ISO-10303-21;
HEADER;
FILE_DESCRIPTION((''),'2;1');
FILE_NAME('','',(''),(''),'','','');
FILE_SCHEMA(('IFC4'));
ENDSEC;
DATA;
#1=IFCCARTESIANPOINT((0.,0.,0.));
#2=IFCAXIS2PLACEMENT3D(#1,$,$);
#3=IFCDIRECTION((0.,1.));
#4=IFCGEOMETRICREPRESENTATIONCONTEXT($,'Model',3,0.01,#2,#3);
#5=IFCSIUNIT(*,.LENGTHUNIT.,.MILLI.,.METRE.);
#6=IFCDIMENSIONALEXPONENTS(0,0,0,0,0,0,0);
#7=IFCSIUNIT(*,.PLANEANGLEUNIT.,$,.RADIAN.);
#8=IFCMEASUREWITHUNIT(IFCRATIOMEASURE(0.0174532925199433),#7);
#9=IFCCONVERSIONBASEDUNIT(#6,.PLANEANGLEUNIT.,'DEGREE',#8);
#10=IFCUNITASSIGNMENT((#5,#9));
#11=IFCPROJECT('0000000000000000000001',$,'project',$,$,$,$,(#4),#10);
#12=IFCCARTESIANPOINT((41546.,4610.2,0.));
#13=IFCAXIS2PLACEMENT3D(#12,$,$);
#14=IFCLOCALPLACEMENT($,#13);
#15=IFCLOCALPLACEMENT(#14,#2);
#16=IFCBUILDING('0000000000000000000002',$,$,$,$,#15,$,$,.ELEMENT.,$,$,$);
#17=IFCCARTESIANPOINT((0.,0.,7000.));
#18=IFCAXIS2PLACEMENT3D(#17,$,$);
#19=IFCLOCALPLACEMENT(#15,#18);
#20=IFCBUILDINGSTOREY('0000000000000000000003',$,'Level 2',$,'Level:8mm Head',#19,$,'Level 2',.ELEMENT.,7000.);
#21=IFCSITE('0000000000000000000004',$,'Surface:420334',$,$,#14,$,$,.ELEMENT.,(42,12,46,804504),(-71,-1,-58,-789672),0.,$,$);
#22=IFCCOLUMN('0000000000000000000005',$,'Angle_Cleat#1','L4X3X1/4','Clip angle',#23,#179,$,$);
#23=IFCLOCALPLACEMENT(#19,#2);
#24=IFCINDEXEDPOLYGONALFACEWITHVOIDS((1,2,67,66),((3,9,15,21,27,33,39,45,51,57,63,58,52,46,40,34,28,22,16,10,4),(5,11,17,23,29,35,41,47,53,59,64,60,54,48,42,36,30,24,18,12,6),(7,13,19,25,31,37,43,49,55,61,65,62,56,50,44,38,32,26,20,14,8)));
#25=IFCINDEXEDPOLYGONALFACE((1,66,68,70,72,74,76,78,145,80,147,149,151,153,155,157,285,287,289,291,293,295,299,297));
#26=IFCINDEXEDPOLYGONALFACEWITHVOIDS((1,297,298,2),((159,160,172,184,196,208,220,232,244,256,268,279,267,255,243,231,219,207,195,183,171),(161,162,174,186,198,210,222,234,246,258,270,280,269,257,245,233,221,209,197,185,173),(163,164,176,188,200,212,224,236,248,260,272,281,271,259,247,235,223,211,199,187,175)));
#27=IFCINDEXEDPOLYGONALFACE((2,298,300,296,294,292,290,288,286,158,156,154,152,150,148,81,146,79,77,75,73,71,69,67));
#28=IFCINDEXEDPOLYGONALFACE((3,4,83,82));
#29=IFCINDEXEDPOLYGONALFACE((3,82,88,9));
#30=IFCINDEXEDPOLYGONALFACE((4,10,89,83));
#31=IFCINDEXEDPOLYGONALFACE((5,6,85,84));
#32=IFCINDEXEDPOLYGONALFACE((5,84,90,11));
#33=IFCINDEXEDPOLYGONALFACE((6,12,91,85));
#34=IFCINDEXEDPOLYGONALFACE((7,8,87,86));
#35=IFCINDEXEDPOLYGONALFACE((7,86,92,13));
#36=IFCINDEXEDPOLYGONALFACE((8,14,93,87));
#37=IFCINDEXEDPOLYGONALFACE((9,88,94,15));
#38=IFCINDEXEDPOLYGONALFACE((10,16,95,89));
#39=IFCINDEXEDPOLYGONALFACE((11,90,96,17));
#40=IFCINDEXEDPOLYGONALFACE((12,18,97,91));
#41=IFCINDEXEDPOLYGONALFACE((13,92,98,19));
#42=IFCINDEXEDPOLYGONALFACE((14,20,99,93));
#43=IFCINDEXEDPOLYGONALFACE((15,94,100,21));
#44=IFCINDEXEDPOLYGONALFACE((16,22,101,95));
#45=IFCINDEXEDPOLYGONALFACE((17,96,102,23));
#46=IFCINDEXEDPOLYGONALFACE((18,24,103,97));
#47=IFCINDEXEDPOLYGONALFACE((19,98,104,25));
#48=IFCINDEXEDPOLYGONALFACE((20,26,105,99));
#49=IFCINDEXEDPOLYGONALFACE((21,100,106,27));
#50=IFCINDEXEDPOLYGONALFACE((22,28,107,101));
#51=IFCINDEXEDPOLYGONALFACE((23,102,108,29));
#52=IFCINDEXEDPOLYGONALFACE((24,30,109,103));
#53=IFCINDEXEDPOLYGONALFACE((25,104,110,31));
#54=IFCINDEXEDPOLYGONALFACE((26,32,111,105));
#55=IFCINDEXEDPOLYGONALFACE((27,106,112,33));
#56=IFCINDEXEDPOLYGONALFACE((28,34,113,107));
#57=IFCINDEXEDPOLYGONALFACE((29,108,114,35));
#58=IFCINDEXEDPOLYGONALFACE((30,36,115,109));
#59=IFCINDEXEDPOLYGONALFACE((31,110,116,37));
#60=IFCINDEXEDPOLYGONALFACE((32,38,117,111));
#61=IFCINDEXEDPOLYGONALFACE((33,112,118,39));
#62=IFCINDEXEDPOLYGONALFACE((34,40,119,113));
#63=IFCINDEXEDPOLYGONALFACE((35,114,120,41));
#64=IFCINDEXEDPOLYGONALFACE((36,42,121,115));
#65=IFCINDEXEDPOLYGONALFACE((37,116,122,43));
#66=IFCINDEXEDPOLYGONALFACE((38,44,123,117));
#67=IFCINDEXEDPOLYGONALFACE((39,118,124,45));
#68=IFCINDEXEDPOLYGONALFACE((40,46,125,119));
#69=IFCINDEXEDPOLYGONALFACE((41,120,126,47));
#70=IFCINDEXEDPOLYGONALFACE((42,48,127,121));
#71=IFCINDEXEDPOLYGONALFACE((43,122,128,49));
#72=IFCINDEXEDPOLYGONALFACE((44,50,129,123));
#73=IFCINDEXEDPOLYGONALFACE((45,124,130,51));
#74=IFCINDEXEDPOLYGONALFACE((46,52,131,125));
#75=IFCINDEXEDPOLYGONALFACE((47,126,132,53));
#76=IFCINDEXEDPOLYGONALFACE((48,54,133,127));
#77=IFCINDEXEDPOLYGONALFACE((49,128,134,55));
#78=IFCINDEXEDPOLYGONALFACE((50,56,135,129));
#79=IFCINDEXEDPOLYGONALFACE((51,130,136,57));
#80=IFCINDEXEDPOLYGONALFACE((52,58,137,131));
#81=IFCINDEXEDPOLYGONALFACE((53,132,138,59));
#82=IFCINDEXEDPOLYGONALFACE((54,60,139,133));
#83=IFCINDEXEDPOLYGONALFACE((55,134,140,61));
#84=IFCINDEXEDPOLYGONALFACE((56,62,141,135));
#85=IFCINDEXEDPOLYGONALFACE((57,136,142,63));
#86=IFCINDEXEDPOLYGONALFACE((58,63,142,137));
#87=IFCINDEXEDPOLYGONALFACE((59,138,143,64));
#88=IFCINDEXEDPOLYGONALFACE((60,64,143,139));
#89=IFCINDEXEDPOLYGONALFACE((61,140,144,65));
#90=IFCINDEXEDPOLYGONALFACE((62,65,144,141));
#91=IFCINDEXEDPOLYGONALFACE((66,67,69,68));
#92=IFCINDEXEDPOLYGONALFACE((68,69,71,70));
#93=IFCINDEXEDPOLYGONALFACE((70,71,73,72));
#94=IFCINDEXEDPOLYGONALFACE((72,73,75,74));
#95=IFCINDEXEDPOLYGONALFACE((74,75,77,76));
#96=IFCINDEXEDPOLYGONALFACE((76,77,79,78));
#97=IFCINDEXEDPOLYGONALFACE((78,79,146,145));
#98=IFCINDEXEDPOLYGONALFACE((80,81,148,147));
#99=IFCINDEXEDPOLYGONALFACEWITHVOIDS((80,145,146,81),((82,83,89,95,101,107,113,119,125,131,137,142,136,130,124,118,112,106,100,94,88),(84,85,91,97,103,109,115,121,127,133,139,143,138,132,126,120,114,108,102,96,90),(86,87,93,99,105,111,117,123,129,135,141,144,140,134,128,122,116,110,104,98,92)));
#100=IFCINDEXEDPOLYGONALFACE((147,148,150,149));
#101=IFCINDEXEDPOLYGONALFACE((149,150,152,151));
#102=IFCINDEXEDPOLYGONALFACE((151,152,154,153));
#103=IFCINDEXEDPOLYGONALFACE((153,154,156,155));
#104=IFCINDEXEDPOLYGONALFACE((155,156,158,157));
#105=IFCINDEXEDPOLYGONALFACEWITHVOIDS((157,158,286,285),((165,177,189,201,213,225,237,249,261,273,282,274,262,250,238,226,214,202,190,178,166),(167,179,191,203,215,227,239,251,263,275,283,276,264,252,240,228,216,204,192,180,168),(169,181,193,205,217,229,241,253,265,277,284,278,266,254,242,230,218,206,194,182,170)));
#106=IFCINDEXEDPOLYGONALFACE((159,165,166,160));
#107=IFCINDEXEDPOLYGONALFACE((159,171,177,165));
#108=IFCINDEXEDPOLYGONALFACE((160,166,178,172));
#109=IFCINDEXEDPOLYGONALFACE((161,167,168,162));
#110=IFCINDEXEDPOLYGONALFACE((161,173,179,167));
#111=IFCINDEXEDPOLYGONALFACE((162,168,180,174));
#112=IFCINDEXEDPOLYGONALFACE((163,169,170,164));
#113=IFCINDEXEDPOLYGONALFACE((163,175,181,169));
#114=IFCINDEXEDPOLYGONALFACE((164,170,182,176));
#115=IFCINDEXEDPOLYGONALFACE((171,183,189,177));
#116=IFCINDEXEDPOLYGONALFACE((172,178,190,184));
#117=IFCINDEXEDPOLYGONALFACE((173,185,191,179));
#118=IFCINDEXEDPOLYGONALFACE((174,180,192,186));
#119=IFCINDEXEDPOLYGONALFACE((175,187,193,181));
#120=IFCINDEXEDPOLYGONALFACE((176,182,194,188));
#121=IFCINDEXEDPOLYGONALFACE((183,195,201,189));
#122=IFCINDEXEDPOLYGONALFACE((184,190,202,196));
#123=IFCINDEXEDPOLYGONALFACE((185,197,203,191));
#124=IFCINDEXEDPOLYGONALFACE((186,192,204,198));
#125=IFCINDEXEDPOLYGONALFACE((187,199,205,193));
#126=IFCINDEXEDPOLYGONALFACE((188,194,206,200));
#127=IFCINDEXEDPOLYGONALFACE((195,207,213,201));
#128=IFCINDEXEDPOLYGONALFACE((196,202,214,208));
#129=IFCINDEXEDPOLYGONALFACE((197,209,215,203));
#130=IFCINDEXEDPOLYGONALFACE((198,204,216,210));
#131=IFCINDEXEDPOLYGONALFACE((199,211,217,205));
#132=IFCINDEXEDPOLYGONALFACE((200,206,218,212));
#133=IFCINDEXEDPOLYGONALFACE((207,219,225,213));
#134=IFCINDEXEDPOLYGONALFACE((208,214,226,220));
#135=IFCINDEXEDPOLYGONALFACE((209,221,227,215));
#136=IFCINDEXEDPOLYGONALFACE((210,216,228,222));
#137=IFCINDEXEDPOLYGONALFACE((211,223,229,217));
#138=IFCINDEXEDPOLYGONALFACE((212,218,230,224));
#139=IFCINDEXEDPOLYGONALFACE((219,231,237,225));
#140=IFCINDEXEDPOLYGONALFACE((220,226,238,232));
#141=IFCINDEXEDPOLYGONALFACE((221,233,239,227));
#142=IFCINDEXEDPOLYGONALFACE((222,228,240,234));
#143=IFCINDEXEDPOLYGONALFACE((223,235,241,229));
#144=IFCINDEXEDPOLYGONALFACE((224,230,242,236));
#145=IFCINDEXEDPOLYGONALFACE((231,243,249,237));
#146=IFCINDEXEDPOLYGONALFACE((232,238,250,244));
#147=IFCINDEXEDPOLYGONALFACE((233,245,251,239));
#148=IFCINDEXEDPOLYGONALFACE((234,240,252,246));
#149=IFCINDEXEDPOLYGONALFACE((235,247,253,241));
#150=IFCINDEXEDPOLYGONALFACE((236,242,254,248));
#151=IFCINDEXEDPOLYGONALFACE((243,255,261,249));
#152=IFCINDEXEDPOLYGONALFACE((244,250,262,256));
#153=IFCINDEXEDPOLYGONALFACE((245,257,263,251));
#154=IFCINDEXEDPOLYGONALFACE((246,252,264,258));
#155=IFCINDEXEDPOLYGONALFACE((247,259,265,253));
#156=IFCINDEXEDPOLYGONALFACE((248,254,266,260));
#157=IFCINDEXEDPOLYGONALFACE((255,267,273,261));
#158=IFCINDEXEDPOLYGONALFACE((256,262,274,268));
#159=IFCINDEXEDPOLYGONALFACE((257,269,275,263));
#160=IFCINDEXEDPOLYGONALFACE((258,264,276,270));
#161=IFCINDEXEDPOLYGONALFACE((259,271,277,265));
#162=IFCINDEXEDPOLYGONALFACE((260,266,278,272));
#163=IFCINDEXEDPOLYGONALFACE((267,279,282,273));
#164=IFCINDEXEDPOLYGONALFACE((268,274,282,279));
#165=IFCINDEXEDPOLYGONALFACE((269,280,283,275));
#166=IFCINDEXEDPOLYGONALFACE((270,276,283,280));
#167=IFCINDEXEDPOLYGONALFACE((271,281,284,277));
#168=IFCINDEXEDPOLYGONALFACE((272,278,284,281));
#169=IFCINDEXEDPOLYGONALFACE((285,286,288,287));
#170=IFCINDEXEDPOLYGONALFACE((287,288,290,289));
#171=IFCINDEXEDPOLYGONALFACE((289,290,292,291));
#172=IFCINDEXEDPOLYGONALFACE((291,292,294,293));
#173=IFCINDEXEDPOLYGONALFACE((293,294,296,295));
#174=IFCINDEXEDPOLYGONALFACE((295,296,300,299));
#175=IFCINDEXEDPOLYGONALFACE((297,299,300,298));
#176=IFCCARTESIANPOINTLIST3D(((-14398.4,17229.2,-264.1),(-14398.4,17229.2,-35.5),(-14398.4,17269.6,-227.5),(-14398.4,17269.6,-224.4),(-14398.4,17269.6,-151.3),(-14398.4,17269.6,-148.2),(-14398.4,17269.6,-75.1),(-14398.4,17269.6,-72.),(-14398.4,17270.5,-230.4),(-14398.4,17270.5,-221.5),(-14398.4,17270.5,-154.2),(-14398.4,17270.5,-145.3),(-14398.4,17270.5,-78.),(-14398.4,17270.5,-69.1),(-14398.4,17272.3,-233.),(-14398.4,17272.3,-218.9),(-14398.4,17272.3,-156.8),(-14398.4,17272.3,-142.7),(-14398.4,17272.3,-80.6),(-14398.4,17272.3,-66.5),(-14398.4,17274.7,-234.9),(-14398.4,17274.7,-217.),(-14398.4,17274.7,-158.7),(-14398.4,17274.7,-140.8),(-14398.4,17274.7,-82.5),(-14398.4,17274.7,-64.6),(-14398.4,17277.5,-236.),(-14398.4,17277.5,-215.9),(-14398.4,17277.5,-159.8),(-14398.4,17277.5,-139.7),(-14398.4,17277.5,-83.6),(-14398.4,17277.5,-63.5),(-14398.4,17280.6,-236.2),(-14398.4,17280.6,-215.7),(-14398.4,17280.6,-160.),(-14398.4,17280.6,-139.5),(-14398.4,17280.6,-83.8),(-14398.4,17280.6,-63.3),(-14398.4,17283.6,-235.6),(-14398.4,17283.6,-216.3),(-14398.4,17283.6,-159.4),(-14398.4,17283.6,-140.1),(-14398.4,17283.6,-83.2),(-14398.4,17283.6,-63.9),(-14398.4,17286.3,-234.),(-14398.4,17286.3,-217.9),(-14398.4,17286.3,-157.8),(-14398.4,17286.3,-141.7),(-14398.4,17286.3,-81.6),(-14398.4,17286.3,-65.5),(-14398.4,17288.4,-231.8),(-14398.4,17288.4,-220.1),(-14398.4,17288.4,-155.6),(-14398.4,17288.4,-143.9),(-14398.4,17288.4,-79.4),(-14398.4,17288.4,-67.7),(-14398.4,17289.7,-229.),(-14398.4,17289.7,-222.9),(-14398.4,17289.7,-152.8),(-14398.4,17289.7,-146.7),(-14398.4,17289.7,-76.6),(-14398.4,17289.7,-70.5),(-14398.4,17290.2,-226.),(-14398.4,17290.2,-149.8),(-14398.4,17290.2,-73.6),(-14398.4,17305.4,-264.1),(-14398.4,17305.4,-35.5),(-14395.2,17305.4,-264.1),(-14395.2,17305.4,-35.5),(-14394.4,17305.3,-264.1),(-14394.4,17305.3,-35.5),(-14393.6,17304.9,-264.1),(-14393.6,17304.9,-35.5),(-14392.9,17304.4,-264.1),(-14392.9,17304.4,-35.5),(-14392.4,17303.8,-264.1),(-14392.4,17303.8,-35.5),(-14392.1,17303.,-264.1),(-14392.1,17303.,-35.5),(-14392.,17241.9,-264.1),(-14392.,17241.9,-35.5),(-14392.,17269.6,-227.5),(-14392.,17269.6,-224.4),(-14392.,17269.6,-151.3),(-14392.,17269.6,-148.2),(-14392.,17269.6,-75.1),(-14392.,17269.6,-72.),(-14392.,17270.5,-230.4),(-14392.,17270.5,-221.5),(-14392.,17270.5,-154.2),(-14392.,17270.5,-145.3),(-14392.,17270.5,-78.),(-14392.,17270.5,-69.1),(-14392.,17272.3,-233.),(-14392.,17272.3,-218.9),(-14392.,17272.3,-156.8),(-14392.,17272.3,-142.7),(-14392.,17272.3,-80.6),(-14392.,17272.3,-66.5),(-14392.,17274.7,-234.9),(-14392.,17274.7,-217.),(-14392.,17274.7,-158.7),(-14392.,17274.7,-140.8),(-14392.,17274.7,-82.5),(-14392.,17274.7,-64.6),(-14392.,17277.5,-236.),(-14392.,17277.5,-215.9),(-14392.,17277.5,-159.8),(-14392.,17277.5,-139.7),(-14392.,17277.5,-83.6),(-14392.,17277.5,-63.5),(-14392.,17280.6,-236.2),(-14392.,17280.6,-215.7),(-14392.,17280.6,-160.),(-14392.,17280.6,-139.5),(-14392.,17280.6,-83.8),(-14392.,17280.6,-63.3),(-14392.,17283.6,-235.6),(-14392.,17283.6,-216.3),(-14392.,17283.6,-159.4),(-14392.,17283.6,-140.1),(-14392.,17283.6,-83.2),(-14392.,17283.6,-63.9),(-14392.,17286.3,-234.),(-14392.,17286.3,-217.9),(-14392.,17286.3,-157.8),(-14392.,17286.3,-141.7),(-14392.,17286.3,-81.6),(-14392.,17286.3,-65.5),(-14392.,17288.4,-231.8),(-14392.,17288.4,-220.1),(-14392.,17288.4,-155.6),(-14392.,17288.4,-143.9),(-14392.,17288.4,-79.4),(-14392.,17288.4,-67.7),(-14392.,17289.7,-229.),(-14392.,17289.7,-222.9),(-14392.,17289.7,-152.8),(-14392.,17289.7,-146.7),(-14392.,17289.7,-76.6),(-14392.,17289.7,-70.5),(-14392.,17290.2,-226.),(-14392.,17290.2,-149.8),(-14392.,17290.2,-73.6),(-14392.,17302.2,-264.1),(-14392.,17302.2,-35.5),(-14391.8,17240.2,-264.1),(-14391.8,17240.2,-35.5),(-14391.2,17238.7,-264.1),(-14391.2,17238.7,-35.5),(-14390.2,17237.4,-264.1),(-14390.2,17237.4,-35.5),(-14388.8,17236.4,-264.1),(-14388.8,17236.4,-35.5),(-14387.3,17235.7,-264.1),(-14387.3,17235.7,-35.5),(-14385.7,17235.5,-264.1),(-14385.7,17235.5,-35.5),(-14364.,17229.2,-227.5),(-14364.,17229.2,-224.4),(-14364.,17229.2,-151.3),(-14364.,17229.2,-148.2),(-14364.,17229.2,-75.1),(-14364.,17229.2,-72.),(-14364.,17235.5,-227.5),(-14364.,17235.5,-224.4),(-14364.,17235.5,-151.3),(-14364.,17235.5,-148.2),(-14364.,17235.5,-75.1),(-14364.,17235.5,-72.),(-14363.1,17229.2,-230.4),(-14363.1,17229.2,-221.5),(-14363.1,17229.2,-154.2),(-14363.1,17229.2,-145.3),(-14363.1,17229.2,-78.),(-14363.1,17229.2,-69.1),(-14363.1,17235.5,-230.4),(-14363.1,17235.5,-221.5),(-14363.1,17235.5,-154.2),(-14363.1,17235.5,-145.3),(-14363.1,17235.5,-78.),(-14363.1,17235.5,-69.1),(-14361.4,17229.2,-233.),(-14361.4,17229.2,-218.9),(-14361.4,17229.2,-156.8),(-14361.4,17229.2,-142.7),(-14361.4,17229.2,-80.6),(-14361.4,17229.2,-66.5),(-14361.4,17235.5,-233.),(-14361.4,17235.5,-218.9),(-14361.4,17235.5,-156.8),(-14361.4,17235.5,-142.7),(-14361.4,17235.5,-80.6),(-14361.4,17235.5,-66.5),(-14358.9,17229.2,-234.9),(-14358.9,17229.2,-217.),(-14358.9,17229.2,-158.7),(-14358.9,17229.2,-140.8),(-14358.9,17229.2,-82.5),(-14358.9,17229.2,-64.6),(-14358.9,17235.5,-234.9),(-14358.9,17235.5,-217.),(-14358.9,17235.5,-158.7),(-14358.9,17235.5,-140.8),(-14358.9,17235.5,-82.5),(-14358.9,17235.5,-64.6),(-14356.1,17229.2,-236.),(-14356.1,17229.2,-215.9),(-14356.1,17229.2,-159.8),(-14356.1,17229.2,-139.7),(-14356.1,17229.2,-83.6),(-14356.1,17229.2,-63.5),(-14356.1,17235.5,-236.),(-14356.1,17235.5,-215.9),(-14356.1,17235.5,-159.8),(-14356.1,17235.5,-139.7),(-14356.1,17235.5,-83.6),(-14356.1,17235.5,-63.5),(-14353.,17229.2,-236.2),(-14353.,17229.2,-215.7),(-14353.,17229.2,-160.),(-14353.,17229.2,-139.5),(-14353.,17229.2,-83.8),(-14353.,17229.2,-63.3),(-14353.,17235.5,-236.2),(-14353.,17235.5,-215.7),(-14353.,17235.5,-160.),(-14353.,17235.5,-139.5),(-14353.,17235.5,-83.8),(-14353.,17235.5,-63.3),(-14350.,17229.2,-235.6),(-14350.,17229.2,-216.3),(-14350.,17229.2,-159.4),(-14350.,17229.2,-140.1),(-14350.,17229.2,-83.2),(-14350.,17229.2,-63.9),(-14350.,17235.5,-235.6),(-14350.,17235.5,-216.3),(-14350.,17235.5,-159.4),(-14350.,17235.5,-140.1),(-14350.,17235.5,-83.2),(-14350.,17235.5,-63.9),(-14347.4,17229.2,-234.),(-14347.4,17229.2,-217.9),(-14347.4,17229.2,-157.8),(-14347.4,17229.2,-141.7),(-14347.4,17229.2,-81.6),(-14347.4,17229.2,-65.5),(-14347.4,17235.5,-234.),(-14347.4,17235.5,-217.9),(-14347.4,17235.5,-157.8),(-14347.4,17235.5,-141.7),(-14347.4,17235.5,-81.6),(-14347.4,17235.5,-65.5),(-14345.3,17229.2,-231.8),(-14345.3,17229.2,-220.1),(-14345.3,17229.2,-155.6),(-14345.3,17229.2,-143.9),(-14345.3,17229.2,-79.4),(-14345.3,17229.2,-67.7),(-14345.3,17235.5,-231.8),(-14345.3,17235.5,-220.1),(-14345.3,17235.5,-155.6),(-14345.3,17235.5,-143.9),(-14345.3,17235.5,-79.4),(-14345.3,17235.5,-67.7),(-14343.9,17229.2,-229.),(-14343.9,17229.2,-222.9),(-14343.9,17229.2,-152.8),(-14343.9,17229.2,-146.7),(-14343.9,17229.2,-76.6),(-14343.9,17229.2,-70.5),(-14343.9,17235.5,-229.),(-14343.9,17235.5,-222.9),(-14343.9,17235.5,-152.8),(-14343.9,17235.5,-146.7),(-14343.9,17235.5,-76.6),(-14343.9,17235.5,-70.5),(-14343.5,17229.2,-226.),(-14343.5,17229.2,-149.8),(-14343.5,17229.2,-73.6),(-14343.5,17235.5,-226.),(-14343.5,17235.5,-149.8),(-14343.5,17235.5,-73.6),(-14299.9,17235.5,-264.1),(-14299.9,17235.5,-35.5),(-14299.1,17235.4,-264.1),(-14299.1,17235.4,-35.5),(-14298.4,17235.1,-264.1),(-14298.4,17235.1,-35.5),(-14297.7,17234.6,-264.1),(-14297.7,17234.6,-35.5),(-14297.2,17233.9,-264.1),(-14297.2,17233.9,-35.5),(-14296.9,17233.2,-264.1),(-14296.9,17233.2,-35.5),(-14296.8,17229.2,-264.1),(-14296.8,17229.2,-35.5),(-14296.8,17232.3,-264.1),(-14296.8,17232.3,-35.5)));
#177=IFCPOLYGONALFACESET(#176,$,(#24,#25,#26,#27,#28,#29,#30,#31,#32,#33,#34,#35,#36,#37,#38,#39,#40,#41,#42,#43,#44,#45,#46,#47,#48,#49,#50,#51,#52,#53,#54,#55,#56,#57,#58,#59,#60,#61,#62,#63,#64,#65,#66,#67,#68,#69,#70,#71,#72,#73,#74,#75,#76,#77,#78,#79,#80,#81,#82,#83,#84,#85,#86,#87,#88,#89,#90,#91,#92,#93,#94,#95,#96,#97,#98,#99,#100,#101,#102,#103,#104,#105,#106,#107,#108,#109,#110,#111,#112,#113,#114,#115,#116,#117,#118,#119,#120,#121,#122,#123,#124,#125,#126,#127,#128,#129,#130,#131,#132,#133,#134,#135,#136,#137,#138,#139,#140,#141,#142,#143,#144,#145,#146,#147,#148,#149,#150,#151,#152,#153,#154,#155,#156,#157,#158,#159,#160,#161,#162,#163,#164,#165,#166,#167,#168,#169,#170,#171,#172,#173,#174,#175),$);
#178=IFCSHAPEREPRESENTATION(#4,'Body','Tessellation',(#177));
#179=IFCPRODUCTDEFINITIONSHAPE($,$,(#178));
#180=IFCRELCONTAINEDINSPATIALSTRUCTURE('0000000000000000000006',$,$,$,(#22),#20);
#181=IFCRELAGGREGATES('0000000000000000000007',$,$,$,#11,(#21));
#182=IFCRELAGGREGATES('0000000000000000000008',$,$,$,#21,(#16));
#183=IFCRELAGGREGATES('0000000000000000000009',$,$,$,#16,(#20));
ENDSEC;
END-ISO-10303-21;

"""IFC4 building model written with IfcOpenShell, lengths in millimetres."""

from ifc_helpers import new_model, entity, si_unit, converted_unit, direction, frame, frame_2d, origin, origin_2d_with_axis, place, context, project, spatial, circle, l_section, extrude, element, save


model = new_model("IFC4")

# Units and contexts
model_context = context("Model", 3, precision=0.01, world=origin(), true_north=direction((0.0, 1.0)))
ifc_project = project(units=[si_unit("LENGTHUNIT", "METRE", prefix="MILLI"), converted_unit("PLANEANGLEUNIT", "DEGREE", entity("IfcRatioMeasure", 0.0174532925199433), si_unit("PLANEANGLEUNIT", "RADIAN"), dimensions=[0, 0, 0, 0, 0, 0, 0])], contexts=[model_context])

# Site, building, storey
site_placement = place(None, frame((41546.0, 4610.2, 0.0)))
site = spatial("IfcSite", under=ifc_project, at=site_placement, Name="Surface:420334", CompositionType="ELEMENT", RefLatitude=(42, 12, 46, 804504), RefLongitude=(-71, -1, -58, -789672), RefElevation=0.0)
building_placement = place(site_placement, origin())
building = spatial("IfcBuilding", under=site, at=building_placement, CompositionType="ELEMENT")
storey_placement = place(building_placement, frame((0.0, 0.0, 7000.0)))
storey = spatial("IfcBuildingStorey", under=building, at=storey_placement, Name="Level 2", ObjectType="Level:8mm Head", LongName="Level 2", CompositionType="ELEMENT", Elevation=7000.0)

# Column, openings
column_1_placement = place(storey_placement, frame((-14367.2, 17247.5, -264.1), z_axis=(0.0, 0.0, -1.0), x_axis=(0.0, 1.0, 0.0)))
column_1 = element("IfcColumn", 1, at=column_1_placement, inside=storey, Name="Angle_Cleat#1", Description="L4X3X1/4", ObjectType="Clip angle", context=model_context, shape_type="SweptSolid", body=[
    extrude(l_section(Depth=101.6, Width=76.2, Thickness=6.3, FilletRadius=6.3, EdgeRadius=3.2, at=frame_2d((19.8, 19.7))), origin(), (0.0, 0.0, -1.0), 228.6),
])
opening_1_placement = place(column_1_placement, frame((32.4, -31.5, -114.3), z_axis=(0.0, 1.0, 0.0), x_axis=(1.0, 0.0, 0.0)))
element("IfcOpeningElement", 2, at=opening_1_placement, cuts=column_1, ObjectType="Opening", context=model_context, shape_type="SweptSolid", body=[
    extrude(circle(Radius=10.3, at=origin_2d_with_axis()), origin(), (0.0, 0.0, 1.0), 7.3),
])
opening_2_placement = place(column_1_placement, frame((32.4, -31.5, -114.3), z_axis=(0.0, 1.0, 0.0), x_axis=(1.0, 0.0, 0.0)))
element("IfcOpeningElement", 3, at=opening_2_placement, cuts=column_1, ObjectType="Opening", context=model_context, shape_type="SweptSolid", body=[
    extrude(circle(Radius=10.3, at=frame_2d((0.0, 76.2), x_axis=(1.0, 0.0))), origin(), (0.0, 0.0, 1.0), 7.3),
])
opening_3_placement = place(column_1_placement, frame((32.4, -31.5, -114.3), z_axis=(0.0, 1.0, 0.0), x_axis=(1.0, 0.0, 0.0)))
element("IfcOpeningElement", 4, at=opening_3_placement, cuts=column_1, ObjectType="Opening", context=model_context, shape_type="SweptSolid", body=[
    extrude(circle(Radius=10.3, at=frame_2d((0.0, -76.2), x_axis=(1.0, 0.0))), origin(), (0.0, 0.0, 1.0), 7.3),
])
opening_4_placement = place(column_1_placement, frame((-18.9, 13.5, -114.3), z_axis=(1.0, 0.0, 0.0), x_axis=(0.0, 1.0, 0.0)))
element("IfcOpeningElement", 5, at=opening_4_placement, cuts=column_1, ObjectType="Opening", context=model_context, shape_type="SweptSolid", body=[
    extrude(circle(Radius=10.3, at=origin_2d_with_axis()), origin(), (0.0, 0.0, 1.0), 7.3),
])
opening_5_placement = place(column_1_placement, frame((-18.9, 13.5, -114.3), z_axis=(1.0, 0.0, 0.0), x_axis=(0.0, 1.0, 0.0)))
element("IfcOpeningElement", 6, at=opening_5_placement, cuts=column_1, ObjectType="Opening", context=model_context, shape_type="SweptSolid", body=[
    extrude(circle(Radius=10.3, at=frame_2d((0.0, 76.2), x_axis=(1.0, 0.0))), origin(), (0.0, 0.0, 1.0), 7.3),
])
opening_6_placement = place(column_1_placement, frame((-18.9, 13.5, -114.3), z_axis=(1.0, 0.0, 0.0), x_axis=(0.0, 1.0, 0.0)))
element("IfcOpeningElement", 7, at=opening_6_placement, cuts=column_1, ObjectType="Opening", context=model_context, shape_type="SweptSolid", body=[
    extrude(circle(Radius=10.3, at=frame_2d((0.0, -76.2), x_axis=(1.0, 0.0))), origin(), (0.0, 0.0, 1.0), 7.3),
])

save(model, "model.ifc")
